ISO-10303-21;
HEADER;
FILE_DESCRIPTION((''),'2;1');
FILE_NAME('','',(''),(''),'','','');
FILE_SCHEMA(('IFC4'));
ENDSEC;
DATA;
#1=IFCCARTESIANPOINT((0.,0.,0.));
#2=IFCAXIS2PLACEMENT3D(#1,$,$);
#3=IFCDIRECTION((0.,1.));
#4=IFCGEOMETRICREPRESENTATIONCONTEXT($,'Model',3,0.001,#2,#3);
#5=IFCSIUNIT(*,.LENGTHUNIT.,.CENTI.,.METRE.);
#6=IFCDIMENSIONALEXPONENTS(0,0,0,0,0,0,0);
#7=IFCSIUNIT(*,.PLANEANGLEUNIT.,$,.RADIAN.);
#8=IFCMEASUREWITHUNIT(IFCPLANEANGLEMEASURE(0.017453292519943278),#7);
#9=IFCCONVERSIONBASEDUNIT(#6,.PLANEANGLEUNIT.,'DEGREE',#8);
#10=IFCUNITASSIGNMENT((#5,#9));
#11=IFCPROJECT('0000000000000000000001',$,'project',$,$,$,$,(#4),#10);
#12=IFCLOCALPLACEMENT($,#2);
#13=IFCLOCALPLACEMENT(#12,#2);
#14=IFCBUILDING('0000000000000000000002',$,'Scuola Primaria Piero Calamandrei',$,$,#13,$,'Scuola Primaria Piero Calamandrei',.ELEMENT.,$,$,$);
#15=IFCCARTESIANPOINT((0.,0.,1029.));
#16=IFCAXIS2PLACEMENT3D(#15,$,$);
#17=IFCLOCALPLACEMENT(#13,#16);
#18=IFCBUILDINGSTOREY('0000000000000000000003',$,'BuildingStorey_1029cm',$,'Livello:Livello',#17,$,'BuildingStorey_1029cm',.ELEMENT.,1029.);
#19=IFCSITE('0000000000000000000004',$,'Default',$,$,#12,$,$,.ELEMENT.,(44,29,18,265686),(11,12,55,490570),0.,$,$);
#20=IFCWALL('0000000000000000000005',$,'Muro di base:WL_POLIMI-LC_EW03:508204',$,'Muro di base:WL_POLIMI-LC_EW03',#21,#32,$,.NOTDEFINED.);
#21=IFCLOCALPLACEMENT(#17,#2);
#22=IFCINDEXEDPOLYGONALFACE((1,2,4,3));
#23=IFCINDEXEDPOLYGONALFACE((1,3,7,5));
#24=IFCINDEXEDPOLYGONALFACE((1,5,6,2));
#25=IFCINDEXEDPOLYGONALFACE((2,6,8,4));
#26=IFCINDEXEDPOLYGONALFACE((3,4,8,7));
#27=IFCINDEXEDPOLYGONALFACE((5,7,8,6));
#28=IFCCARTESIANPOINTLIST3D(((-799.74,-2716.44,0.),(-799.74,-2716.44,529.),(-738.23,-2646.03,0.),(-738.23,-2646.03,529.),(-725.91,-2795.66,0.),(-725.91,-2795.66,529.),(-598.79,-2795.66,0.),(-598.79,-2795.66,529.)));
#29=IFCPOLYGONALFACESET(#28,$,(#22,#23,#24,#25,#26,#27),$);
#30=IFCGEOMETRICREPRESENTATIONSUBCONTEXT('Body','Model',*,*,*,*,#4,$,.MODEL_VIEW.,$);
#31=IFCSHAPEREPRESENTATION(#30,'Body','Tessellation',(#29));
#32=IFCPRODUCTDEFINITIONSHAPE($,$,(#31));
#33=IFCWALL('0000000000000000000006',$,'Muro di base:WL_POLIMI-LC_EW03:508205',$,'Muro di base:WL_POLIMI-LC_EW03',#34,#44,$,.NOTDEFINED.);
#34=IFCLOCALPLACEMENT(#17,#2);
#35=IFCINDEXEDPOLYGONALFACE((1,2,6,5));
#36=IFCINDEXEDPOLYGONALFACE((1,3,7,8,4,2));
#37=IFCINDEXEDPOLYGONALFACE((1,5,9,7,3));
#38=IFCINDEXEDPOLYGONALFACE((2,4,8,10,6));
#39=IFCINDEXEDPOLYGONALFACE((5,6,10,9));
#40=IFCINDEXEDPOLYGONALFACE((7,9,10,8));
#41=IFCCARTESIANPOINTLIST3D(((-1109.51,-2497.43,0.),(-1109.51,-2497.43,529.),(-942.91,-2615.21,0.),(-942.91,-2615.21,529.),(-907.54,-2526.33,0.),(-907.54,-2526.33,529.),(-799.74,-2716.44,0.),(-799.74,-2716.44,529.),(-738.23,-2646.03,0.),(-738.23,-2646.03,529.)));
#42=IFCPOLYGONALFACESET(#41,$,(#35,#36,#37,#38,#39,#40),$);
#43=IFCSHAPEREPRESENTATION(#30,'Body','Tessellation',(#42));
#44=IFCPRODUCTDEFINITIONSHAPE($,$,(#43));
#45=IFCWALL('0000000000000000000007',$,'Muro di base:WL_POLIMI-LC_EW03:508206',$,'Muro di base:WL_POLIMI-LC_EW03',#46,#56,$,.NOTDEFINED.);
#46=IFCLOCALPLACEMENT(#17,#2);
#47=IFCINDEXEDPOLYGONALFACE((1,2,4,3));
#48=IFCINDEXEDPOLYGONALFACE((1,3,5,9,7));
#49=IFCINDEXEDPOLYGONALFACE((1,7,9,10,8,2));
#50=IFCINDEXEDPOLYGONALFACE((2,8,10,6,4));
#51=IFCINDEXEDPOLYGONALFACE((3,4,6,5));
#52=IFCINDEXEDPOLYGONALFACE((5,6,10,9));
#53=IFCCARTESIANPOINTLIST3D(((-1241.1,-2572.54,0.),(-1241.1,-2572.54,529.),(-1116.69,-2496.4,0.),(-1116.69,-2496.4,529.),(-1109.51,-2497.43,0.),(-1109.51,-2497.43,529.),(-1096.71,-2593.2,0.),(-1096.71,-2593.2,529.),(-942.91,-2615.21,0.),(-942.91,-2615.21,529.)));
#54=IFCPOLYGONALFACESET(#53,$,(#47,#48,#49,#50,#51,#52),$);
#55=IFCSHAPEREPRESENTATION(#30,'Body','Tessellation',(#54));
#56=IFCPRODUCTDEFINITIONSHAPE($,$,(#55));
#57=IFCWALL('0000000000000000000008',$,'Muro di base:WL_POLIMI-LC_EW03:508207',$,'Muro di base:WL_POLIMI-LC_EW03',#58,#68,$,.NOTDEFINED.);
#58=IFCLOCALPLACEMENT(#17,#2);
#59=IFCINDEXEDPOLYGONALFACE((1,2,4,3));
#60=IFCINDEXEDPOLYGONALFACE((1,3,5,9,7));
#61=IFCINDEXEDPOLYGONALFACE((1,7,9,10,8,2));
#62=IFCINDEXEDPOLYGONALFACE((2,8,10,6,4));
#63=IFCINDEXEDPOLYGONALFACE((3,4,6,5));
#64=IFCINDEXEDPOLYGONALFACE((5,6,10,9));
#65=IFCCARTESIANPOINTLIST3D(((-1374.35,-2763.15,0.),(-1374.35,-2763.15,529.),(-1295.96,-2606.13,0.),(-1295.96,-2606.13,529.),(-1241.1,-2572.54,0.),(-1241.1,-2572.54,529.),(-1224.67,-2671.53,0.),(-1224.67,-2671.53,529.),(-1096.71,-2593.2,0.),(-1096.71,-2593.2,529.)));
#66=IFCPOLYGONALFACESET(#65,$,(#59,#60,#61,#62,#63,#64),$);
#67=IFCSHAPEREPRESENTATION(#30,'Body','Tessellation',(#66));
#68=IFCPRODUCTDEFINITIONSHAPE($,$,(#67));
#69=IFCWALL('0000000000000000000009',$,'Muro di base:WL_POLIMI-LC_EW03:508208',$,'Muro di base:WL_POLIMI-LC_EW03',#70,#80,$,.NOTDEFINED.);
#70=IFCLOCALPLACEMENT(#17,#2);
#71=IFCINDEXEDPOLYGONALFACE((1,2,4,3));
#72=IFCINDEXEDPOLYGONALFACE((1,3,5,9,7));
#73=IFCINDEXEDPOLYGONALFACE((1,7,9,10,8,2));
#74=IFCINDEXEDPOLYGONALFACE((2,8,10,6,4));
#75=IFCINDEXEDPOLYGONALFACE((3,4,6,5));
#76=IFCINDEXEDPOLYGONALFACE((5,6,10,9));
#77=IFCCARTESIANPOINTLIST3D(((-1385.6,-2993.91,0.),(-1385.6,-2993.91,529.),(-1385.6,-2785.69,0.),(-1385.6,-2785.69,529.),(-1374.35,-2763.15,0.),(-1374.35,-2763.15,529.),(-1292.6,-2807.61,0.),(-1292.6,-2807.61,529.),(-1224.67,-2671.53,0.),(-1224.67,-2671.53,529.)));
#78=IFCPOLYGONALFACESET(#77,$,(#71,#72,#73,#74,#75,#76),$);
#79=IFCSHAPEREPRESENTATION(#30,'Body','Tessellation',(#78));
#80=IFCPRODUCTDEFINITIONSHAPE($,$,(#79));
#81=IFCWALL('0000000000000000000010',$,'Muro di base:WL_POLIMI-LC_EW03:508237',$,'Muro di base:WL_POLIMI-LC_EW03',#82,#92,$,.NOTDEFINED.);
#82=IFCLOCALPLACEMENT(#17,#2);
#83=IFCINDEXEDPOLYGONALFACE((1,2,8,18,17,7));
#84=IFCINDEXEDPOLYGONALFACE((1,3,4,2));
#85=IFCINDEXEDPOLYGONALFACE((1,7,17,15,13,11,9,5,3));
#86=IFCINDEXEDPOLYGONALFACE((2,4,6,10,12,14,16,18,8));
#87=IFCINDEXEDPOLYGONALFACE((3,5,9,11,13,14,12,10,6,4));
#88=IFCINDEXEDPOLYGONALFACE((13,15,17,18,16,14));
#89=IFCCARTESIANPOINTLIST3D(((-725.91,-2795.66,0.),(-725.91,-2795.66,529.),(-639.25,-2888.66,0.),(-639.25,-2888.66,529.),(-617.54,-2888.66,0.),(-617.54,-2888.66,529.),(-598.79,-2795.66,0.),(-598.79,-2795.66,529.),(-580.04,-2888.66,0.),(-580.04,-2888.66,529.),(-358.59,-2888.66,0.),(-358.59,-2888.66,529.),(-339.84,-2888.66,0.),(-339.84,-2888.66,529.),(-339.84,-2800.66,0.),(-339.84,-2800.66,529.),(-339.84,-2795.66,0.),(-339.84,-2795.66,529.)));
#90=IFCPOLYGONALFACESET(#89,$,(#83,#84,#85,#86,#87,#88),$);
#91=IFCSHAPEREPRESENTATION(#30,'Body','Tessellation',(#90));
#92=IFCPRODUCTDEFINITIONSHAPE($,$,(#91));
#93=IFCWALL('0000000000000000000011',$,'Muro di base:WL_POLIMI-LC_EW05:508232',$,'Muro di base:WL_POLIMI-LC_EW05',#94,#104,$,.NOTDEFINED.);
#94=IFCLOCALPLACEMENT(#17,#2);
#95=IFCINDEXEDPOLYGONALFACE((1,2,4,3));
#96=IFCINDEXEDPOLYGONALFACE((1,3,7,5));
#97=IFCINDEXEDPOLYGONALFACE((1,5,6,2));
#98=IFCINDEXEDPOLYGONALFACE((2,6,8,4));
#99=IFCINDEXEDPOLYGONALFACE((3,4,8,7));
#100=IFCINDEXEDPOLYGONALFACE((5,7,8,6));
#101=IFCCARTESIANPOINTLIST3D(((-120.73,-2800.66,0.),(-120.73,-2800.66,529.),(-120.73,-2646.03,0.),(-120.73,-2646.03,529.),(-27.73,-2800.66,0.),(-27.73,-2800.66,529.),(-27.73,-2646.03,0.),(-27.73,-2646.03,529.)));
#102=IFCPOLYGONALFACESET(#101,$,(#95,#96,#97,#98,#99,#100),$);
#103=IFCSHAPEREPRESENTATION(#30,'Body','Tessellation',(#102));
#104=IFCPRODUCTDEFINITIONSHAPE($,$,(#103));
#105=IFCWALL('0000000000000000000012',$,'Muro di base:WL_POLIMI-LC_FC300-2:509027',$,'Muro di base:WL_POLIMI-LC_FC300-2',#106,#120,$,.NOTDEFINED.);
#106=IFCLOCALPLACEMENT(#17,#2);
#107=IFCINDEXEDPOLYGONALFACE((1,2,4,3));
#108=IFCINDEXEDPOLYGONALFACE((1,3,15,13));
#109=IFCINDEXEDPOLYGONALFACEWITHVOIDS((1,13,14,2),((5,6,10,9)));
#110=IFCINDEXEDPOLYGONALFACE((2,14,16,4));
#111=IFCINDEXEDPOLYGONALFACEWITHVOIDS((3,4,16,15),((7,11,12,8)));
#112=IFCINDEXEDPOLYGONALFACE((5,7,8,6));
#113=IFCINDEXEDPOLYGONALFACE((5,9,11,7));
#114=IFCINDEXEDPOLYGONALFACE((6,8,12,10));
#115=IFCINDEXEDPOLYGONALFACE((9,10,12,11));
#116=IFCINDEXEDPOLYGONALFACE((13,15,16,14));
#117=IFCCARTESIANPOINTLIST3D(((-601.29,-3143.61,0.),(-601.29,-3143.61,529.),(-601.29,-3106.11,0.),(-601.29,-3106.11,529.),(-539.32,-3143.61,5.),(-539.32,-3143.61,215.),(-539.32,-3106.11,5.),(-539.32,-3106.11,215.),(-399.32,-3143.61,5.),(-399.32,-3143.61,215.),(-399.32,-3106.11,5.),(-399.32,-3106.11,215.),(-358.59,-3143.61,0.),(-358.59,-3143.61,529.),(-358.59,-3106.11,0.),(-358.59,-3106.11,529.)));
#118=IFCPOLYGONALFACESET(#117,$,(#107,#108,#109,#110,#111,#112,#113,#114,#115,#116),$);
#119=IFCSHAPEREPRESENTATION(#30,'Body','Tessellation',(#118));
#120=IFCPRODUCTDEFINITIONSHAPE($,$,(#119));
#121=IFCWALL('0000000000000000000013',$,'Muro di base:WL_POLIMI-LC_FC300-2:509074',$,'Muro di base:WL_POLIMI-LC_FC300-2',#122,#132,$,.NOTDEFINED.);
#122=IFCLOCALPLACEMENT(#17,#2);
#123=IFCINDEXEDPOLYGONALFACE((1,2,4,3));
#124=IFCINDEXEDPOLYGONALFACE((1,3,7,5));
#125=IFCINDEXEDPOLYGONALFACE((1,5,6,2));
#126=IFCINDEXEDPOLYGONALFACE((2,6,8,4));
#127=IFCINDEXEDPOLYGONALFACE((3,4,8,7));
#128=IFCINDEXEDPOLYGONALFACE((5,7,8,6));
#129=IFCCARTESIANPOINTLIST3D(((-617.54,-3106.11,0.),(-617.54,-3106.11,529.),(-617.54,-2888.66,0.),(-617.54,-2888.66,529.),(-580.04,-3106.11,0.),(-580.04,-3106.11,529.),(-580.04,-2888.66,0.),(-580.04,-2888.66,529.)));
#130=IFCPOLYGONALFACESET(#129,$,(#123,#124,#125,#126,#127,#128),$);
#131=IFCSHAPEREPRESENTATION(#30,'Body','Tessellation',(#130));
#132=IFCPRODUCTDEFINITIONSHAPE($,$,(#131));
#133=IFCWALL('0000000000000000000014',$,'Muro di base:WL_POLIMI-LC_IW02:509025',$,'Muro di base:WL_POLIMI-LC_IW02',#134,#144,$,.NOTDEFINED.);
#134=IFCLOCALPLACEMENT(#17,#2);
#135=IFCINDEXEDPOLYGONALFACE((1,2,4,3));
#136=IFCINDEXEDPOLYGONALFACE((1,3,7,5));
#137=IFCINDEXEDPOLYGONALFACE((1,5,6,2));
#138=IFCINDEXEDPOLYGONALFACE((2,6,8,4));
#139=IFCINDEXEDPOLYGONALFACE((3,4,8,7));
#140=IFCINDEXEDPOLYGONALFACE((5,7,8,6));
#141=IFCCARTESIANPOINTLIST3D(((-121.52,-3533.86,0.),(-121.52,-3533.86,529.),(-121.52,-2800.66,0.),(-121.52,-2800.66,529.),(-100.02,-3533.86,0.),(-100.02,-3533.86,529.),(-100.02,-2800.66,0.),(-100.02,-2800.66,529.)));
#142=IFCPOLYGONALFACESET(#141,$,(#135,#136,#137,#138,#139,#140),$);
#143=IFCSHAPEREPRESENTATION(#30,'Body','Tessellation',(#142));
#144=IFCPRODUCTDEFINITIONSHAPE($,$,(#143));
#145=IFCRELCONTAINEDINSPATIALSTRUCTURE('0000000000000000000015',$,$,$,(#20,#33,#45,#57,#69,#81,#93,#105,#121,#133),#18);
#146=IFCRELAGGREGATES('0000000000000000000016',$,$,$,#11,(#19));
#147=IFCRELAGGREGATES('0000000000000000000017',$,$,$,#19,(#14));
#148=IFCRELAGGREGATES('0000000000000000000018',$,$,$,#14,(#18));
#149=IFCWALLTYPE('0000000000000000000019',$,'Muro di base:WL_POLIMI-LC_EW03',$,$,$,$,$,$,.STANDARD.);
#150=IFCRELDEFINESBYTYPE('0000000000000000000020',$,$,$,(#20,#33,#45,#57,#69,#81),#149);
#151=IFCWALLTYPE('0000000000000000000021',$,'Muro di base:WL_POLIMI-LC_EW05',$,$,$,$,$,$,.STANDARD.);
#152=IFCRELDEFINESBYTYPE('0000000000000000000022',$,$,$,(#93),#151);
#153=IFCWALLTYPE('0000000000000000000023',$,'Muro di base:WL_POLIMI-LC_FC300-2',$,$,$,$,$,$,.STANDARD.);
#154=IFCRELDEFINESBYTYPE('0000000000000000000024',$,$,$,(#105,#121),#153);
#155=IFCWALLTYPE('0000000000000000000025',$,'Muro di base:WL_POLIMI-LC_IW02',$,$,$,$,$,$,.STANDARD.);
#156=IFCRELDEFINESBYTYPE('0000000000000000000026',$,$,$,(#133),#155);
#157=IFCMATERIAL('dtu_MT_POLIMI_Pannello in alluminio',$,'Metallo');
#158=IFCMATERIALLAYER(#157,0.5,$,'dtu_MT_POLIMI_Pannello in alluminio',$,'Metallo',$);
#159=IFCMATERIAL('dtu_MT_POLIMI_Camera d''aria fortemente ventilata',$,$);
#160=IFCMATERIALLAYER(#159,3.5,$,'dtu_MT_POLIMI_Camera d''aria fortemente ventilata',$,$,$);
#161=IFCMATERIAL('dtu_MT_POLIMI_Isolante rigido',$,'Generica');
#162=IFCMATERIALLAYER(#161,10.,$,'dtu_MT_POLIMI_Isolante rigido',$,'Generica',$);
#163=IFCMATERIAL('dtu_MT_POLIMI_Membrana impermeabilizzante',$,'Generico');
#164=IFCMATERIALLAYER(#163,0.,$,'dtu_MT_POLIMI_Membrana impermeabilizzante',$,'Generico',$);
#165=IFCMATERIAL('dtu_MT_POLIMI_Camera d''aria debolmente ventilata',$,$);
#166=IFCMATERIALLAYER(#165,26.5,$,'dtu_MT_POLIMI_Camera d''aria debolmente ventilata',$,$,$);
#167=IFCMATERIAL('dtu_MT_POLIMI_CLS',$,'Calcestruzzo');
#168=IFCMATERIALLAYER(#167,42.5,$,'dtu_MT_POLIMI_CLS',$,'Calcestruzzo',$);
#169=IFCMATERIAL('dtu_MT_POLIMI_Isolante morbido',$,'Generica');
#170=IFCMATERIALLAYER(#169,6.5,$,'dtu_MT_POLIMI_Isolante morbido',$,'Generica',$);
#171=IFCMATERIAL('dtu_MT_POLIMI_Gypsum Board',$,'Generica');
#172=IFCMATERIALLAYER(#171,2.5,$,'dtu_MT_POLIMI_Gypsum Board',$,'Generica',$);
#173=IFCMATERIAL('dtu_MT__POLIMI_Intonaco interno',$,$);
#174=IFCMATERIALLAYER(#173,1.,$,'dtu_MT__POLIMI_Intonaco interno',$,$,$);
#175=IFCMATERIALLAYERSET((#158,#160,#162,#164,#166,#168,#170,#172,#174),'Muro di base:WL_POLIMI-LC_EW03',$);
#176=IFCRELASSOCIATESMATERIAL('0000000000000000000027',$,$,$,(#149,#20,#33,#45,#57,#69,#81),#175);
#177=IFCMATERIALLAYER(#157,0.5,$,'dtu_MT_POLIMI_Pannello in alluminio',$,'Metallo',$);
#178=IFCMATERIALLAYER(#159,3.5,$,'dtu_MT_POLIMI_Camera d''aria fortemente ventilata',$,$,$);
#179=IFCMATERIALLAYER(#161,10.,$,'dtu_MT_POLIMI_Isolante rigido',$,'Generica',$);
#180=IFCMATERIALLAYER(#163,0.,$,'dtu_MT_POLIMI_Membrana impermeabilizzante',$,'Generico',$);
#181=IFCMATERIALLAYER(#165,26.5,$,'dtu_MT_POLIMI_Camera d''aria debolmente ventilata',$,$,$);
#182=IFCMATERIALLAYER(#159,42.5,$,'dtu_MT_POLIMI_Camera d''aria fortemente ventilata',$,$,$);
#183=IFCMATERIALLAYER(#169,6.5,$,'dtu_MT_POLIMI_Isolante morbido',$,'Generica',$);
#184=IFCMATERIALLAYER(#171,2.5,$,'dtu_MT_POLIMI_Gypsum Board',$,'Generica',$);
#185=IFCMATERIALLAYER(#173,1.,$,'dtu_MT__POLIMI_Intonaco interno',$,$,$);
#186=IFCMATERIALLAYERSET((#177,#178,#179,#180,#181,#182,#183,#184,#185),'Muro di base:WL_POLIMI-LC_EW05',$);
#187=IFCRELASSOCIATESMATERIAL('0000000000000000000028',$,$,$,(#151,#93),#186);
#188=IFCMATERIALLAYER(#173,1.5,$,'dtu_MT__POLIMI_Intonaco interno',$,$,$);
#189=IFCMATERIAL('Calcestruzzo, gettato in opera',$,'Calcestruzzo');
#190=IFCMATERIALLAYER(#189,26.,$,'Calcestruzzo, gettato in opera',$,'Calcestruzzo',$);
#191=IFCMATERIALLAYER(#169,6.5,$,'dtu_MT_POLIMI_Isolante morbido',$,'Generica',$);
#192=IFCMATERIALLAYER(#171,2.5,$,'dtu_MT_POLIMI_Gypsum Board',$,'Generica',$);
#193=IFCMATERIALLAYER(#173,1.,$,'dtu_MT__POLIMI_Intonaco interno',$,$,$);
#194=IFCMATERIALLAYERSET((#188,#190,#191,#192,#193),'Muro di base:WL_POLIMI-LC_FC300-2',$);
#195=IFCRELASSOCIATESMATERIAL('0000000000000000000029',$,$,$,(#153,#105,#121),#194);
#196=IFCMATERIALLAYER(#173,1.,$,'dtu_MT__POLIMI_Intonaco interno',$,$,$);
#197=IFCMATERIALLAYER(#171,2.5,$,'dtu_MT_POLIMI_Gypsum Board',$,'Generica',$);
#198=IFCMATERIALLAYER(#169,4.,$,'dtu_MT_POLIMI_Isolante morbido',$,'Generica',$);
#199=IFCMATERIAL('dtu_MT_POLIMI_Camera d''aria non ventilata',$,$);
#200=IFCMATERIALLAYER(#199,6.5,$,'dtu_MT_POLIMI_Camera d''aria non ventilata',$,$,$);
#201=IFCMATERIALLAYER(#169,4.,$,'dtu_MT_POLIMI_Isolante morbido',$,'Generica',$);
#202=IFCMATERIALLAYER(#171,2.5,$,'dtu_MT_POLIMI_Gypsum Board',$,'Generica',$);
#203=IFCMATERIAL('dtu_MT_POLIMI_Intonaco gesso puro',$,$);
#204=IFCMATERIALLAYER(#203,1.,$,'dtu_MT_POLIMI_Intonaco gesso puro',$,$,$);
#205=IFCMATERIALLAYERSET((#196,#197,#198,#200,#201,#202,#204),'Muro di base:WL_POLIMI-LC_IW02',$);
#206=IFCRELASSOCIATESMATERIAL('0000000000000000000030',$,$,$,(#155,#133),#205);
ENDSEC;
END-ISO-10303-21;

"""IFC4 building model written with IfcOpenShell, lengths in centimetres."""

from ifc_helpers import new_model, entity, si_unit, converted_unit, direction, frame, frame_2d, origin, place, context, subcontext, project, spatial, polyline, rectangle, outline, extrude, material, layer, layer_set, layer_usage, type_object, element, save


model = new_model("IFC4")

# Units and contexts
model_context = context("Model", 3, precision=0.001, world=origin(), true_north=direction((0.0, 1.0)))
body_context = subcontext(model_context, "Body", "Model", "MODEL_VIEW")
ifc_project = project(units=[si_unit("LENGTHUNIT", "METRE", prefix="CENTI"), converted_unit("PLANEANGLEUNIT", "DEGREE", entity("IfcPlaneAngleMeasure", 0.017453292519943278), si_unit("PLANEANGLEUNIT", "RADIAN"), dimensions=[0, 0, 0, 0, 0, 0, 0])], contexts=[model_context])

# Site, building, storey
site_placement = place(None, origin())
site = spatial("IfcSite", under=ifc_project, at=site_placement, Name="Default", CompositionType="ELEMENT", RefLatitude=(44, 29, 18, 265686), RefLongitude=(11, 12, 55, 490570), RefElevation=0.0)
building_placement = place(site_placement, origin())
building = spatial("IfcBuilding", under=site, at=building_placement, Name="Scuola Primaria Piero Calamandrei", LongName="Scuola Primaria Piero Calamandrei", CompositionType="ELEMENT")
storey_placement = place(building_placement, frame((0.0, 0.0, 1029.0)))
storey = spatial("IfcBuildingStorey", under=building, at=storey_placement, Name="BuildingStorey_1029cm", ObjectType="Livello:Livello", LongName="BuildingStorey_1029cm", CompositionType="ELEMENT", Elevation=1029.0)

# Shared definitions
ifc_material_1 = material(Name="dtu_MT_POLIMI_Isolante rigido", Category="Generica")
ifc_material_2 = material(Name="dtu_MT__POLIMI_Intonaco interno")

# Walls
ifc_material_3 = material(Name="dtu_MT_POLIMI_Pannello in alluminio", Category="Metallo")
ifc_layer_1 = layer(ifc_material_3, 0.5, Name="dtu_MT_POLIMI_Pannello in alluminio", Category="Metallo")
ifc_material_4 = material(Name="dtu_MT_POLIMI_Camera d'aria fortemente ventilata")
ifc_layer_2 = layer(ifc_material_4, 3.5, Name="dtu_MT_POLIMI_Camera d'aria fortemente ventilata")
ifc_layer_3 = layer(ifc_material_1, 10.0, Name="dtu_MT_POLIMI_Isolante rigido", Category="Generica")
ifc_material_5 = material(Name="dtu_MT_POLIMI_Membrana impermeabilizzante", Category="Generico")
ifc_layer_4 = layer(ifc_material_5, 0.0, Name="dtu_MT_POLIMI_Membrana impermeabilizzante", Category="Generico")
ifc_material_6 = material(Name="dtu_MT_POLIMI_Camera d'aria debolmente ventilata")
ifc_layer_5 = layer(ifc_material_6, 26.5, Name="dtu_MT_POLIMI_Camera d'aria debolmente ventilata")
ifc_material_7 = material(Name="dtu_MT_POLIMI_CLS", Category="Calcestruzzo")
ifc_layer_6 = layer(ifc_material_7, 42.5, Name="dtu_MT_POLIMI_CLS", Category="Calcestruzzo")
ifc_material_8 = material(Name="dtu_MT_POLIMI_Isolante morbido", Category="Generica")
ifc_layer_7 = layer(ifc_material_8, 6.5, Name="dtu_MT_POLIMI_Isolante morbido", Category="Generica")
ifc_material_9 = material(Name="dtu_MT_POLIMI_Gypsum Board", Category="Generica")
ifc_layer_8 = layer(ifc_material_9, 2.5, Name="dtu_MT_POLIMI_Gypsum Board", Category="Generica")
ifc_layer_9 = layer(ifc_material_2, 1.0, Name="dtu_MT__POLIMI_Intonaco interno")
ifc_layer_set_1 = layer_set([ifc_layer_1, ifc_layer_2, ifc_layer_3, ifc_layer_4, ifc_layer_5, ifc_layer_6, ifc_layer_7, ifc_layer_8, ifc_layer_9], Name="Muro di base:WL_POLIMI-LC_EW03")
ifc_layer_usage_1 = layer_usage(ifc_layer_set_1, "AXIS2", "NEGATIVE", 46.5)
wall_type_1 = type_object("IfcWallType", Name="Muro di base:WL_POLIMI-LC_EW03", PredefinedType="STANDARD", material=ifc_layer_set_1)
wall_1_placement = place(storey_placement, frame((-772.25, -2677.73, 0.0), z_axis=(0.0, 0.0, 1.0), x_axis=(0.681735, -0.731599, 0.0)))
element("IfcWall", 1, at=wall_1_placement, inside=storey, type_object=wall_type_1, material=ifc_layer_usage_1, Name="Muro di base:WL_POLIMI-LC_EW03:508204", ObjectType="Muro di base:WL_POLIMI-LC_EW03", PredefinedType="NOTDEFINED", context=body_context, shape_type="SweptSolid", body=[
    extrude(outline(polyline([(117.87, -46.5), (204.53, 46.5), (0.0, 46.5), (9.58, -46.5), (117.87, -46.5)])), origin(), (0.0, 0.0, 1.0), 529.0),
])
ifc_layer_usage_2 = layer_usage(ifc_layer_set_1, "AXIS2", "NEGATIVE", 46.5)
wall_2_placement = place(storey_placement, frame((-1082.67, -2459.46, 0.0), z_axis=(0.0, 0.0, 1.0), x_axis=(0.816533, -0.577299, 0.0)))
element("IfcWall", 2, at=wall_2_placement, inside=storey, type_object=wall_type_1, material=ifc_layer_usage_2, Name="Muro di base:WL_POLIMI-LC_EW03:508205", ObjectType="Muro di base:WL_POLIMI-LC_EW03", PredefinedType="NOTDEFINED", context=body_context, shape_type="SweptSolid", body=[
    extrude(outline(polyline([(379.38, -46.5), (388.96, 46.5), (181.6, 46.5), (0.0, -46.5), (204.03, -46.5), (379.38, -46.5)])), origin(), (0.0, 0.0, 1.0), 529.0),
])
ifc_layer_usage_3 = layer_usage(ifc_layer_set_1, "AXIS2", "NEGATIVE", 46.5)
wall_3_placement = place(storey_placement, frame((-1234.51, -2526.51, 0.0), z_axis=(0.0, 0.0, 1.0), x_axis=(0.989918, -0.141644, 0.0)))
element("IfcWall", 3, at=wall_3_placement, inside=storey, type_object=wall_type_1, material=ifc_layer_usage_3, Name="Muro di base:WL_POLIMI-LC_EW03:508206", ObjectType="Muro di base:WL_POLIMI-LC_EW03", PredefinedType="NOTDEFINED", context=body_context, shape_type="SweptSolid", body=[
    extrude(outline(polyline([(301.22, -46.5), (119.62, 46.5), (112.36, 46.5), (0.0, -46.5), (145.86, -46.5), (301.22, -46.5)])), origin(), (0.0, 0.0, 1.0), 529.0),
])
ifc_layer_usage_4 = layer_usage(ifc_layer_set_1, "AXIS2", "NEGATIVE", 46.5)
wall_4_placement = place(storey_placement, frame((-1398.62, -2723.48, 0.0), z_axis=(0.0, 0.0, 1.0), x_axis=(0.85291, 0.522058, 0.0)))
element("IfcWall", 4, at=wall_4_placement, inside=storey, type_object=wall_type_1, material=ifc_layer_usage_4, Name="Muro di base:WL_POLIMI-LC_EW03:508207", ObjectType="Muro di base:WL_POLIMI-LC_EW03", PredefinedType="NOTDEFINED", context=body_context, shape_type="SweptSolid", body=[
    extrude(outline(polyline([(325.52, -46.5), (213.16, 46.5), (148.82, 46.5), (0.0, -46.5), (175.49, -46.5), (325.52, -46.5)])), origin(), (0.0, 0.0, 1.0), 529.0),
])
ifc_layer_usage_5 = layer_usage(ifc_layer_set_1, "AXIS2", "NEGATIVE", 46.5)
wall_5_placement = place(storey_placement, frame((-1427.21, -2973.14, 0.0), z_axis=(0.0, 0.0, 1.0), x_axis=(0.446642, 0.894713, 0.0)))
element("IfcWall", 5, at=wall_5_placement, inside=storey, type_object=wall_type_1, material=ifc_layer_usage_5, Name="Muro di base:WL_POLIMI-LC_EW03:508208", ObjectType="Muro di base:WL_POLIMI-LC_EW03", PredefinedType="NOTDEFINED", context=body_context, shape_type="SweptSolid", body=[
    extrude(outline(polyline([(360.32, -46.5), (211.49, 46.5), (186.3, 46.5), (0.0, -46.5), (208.22, -46.5), (360.32, -46.5)])), origin(), (0.0, 0.0, 1.0), 529.0),
])
ifc_layer_usage_6 = layer_usage(ifc_layer_set_1, "AXIS2", "NEGATIVE", 46.5)
wall_6_placement = place(storey_placement, frame((-725.91, -2842.16, 0.0)))
element("IfcWall", 6, at=wall_6_placement, inside=storey, type_object=wall_type_1, material=ifc_layer_usage_6, Name="Muro di base:WL_POLIMI-LC_EW03:508237", ObjectType="Muro di base:WL_POLIMI-LC_EW03", PredefinedType="NOTDEFINED", context=body_context, shape_type="SweptSolid", body=[
    extrude(outline(polyline([(386.07, -46.5), (386.07, 41.5), (386.07, 46.5), (127.12, 46.5), (0.0, 46.5), (86.66, -46.5), (108.37, -46.5), (145.87, -46.5), (367.32, -46.5), (386.07, -46.5)])), origin(), (0.0, 0.0, 1.0), 529.0),
])
ifc_layer_10 = layer(ifc_material_3, 0.5, Name="dtu_MT_POLIMI_Pannello in alluminio", Category="Metallo")
ifc_layer_11 = layer(ifc_material_4, 3.5, Name="dtu_MT_POLIMI_Camera d'aria fortemente ventilata")
ifc_layer_12 = layer(ifc_material_1, 10.0, Name="dtu_MT_POLIMI_Isolante rigido", Category="Generica")
ifc_layer_13 = layer(ifc_material_5, 0.0, Name="dtu_MT_POLIMI_Membrana impermeabilizzante", Category="Generico")
ifc_layer_14 = layer(ifc_material_6, 26.5, Name="dtu_MT_POLIMI_Camera d'aria debolmente ventilata")
ifc_layer_15 = layer(ifc_material_4, 42.5, Name="dtu_MT_POLIMI_Camera d'aria fortemente ventilata")
ifc_layer_16 = layer(ifc_material_8, 6.5, Name="dtu_MT_POLIMI_Isolante morbido", Category="Generica")
ifc_layer_17 = layer(ifc_material_9, 2.5, Name="dtu_MT_POLIMI_Gypsum Board", Category="Generica")
ifc_layer_18 = layer(ifc_material_2, 1.0, Name="dtu_MT__POLIMI_Intonaco interno")
ifc_layer_set_2 = layer_set([ifc_layer_10, ifc_layer_11, ifc_layer_12, ifc_layer_13, ifc_layer_14, ifc_layer_15, ifc_layer_16, ifc_layer_17, ifc_layer_18], Name="Muro di base:WL_POLIMI-LC_EW05")
ifc_layer_usage_7 = layer_usage(ifc_layer_set_2, "AXIS2", "NEGATIVE", 46.5)
wall_type_2 = type_object("IfcWallType", Name="Muro di base:WL_POLIMI-LC_EW05", PredefinedType="STANDARD", material=ifc_layer_set_2)
wall_7_placement = place(storey_placement, frame((-74.23, -2800.66, 0.0), z_axis=(0.0, 0.0, 1.0), x_axis=(0.0, 1.0, 0.0)))
element("IfcWall", 7, at=wall_7_placement, inside=storey, type_object=wall_type_2, material=ifc_layer_usage_7, Name="Muro di base:WL_POLIMI-LC_EW05:508232", ObjectType="Muro di base:WL_POLIMI-LC_EW05", PredefinedType="NOTDEFINED", context=body_context, shape_type="SweptSolid", body=[
    extrude(rectangle(XDim=154.63, YDim=93.0, at=frame_2d((77.32, 0.0), x_axis=(-1.0, 0.0))), origin(), (0.0, 0.0, 1.0), 529.0),
])
ifc_layer_19 = layer(ifc_material_2, 1.5, Name="dtu_MT__POLIMI_Intonaco interno")
ifc_material_10 = material(Name="Calcestruzzo, gettato in opera", Category="Calcestruzzo")
ifc_layer_20 = layer(ifc_material_10, 26.0, Name="Calcestruzzo, gettato in opera", Category="Calcestruzzo")
ifc_layer_21 = layer(ifc_material_8, 6.5, Name="dtu_MT_POLIMI_Isolante morbido", Category="Generica")
ifc_layer_22 = layer(ifc_material_9, 2.5, Name="dtu_MT_POLIMI_Gypsum Board", Category="Generica")
ifc_layer_23 = layer(ifc_material_2, 1.0, Name="dtu_MT__POLIMI_Intonaco interno")
ifc_layer_set_3 = layer_set([ifc_layer_19, ifc_layer_20, ifc_layer_21, ifc_layer_22, ifc_layer_23], Name="Muro di base:WL_POLIMI-LC_FC300-2")
wall_type_3 = type_object("IfcWallType", Name="Muro di base:WL_POLIMI-LC_FC300-2", PredefinedType="STANDARD", material=ifc_layer_set_3)

# Wall, opening
ifc_layer_usage_8 = layer_usage(ifc_layer_set_3, "AXIS2", "NEGATIVE", 18.75)
wall_8_placement = place(storey_placement, frame((-601.29, -3124.86, 0.0)))
wall_8 = element("IfcWall", 8, at=wall_8_placement, inside=storey, type_object=wall_type_3, material=ifc_layer_usage_8, Name="Muro di base:WL_POLIMI-LC_FC300-2:509027", ObjectType="Muro di base:WL_POLIMI-LC_FC300-2", PredefinedType="NOTDEFINED", context=body_context, shape_type="SweptSolid", body=[
    extrude(rectangle(XDim=242.7, YDim=37.5, at=frame_2d((121.35, 0.0), x_axis=(-1.0, 0.0))), origin(), (0.0, 0.0, 1.0), 529.0),
])
opening_1_placement = place(wall_8_placement, frame((61.98, -18.75, 5.0)))
element("IfcOpeningElement", 9, at=opening_1_placement, cuts=wall_8, PredefinedType="OPENING", context=body_context, shape_type="SweptSolid", body=[
    extrude(rectangle(XDim=210.0, YDim=140.0, at=frame_2d((105.0, 70.0), x_axis=(1.0, 0.0))), frame((0.0, 0.0, 0.0), z_axis=(0.0, 1.0, 0.0), x_axis=(0.0, 0.0, 1.0)), (0.0, 0.0, 1.0), 37.5),
])

# Walls
ifc_layer_usage_9 = layer_usage(ifc_layer_set_3, "AXIS2", "NEGATIVE", 18.75)
wall_9_placement = place(storey_placement, frame((-598.79, -2888.66, 0.0), z_axis=(0.0, 0.0, 1.0), x_axis=(0.0, -1.0, 0.0)))
element("IfcWall", 10, at=wall_9_placement, inside=storey, type_object=wall_type_3, material=ifc_layer_usage_9, Name="Muro di base:WL_POLIMI-LC_FC300-2:509074", ObjectType="Muro di base:WL_POLIMI-LC_FC300-2", PredefinedType="NOTDEFINED", context=body_context, shape_type="SweptSolid", body=[
    extrude(rectangle(XDim=217.44, YDim=37.5, at=frame_2d((108.72, 0.0), x_axis=(-1.0, 0.0))), origin(), (0.0, 0.0, 1.0), 529.0),
])
ifc_layer_24 = layer(ifc_material_2, 1.0, Name="dtu_MT__POLIMI_Intonaco interno")
ifc_layer_25 = layer(ifc_material_9, 2.5, Name="dtu_MT_POLIMI_Gypsum Board", Category="Generica")
ifc_layer_26 = layer(ifc_material_8, 4.0, Name="dtu_MT_POLIMI_Isolante morbido", Category="Generica")
ifc_material_11 = material(Name="dtu_MT_POLIMI_Camera d'aria non ventilata")
ifc_layer_27 = layer(ifc_material_11, 6.5, Name="dtu_MT_POLIMI_Camera d'aria non ventilata")
ifc_layer_28 = layer(ifc_material_8, 4.0, Name="dtu_MT_POLIMI_Isolante morbido", Category="Generica")
ifc_layer_29 = layer(ifc_material_9, 2.5, Name="dtu_MT_POLIMI_Gypsum Board", Category="Generica")
ifc_material_12 = material(Name="dtu_MT_POLIMI_Intonaco gesso puro")
ifc_layer_30 = layer(ifc_material_12, 1.0, Name="dtu_MT_POLIMI_Intonaco gesso puro")
ifc_layer_set_4 = layer_set([ifc_layer_24, ifc_layer_25, ifc_layer_26, ifc_layer_27, ifc_layer_28, ifc_layer_29, ifc_layer_30], Name="Muro di base:WL_POLIMI-LC_IW02")
ifc_layer_usage_10 = layer_usage(ifc_layer_set_4, "AXIS2", "NEGATIVE", 10.75)
wall_type_4 = type_object("IfcWallType", Name="Muro di base:WL_POLIMI-LC_IW02", PredefinedType="STANDARD", material=ifc_layer_set_4)
wall_10_placement = place(storey_placement, frame((-110.77, -2800.66, 0.0), z_axis=(0.0, 0.0, 1.0), x_axis=(0.0, -1.0, 0.0)))
element("IfcWall", 11, at=wall_10_placement, inside=storey, type_object=wall_type_4, material=ifc_layer_usage_10, Name="Muro di base:WL_POLIMI-LC_IW02:509025", ObjectType="Muro di base:WL_POLIMI-LC_IW02", PredefinedType="NOTDEFINED", context=body_context, shape_type="SweptSolid", body=[
    extrude(rectangle(XDim=733.19, YDim=21.5, at=frame_2d((366.6, 0.0), x_axis=(-1.0, 0.0))), origin(), (0.0, 0.0, 1.0), 529.0),
])

save(model, "model.ifc")
